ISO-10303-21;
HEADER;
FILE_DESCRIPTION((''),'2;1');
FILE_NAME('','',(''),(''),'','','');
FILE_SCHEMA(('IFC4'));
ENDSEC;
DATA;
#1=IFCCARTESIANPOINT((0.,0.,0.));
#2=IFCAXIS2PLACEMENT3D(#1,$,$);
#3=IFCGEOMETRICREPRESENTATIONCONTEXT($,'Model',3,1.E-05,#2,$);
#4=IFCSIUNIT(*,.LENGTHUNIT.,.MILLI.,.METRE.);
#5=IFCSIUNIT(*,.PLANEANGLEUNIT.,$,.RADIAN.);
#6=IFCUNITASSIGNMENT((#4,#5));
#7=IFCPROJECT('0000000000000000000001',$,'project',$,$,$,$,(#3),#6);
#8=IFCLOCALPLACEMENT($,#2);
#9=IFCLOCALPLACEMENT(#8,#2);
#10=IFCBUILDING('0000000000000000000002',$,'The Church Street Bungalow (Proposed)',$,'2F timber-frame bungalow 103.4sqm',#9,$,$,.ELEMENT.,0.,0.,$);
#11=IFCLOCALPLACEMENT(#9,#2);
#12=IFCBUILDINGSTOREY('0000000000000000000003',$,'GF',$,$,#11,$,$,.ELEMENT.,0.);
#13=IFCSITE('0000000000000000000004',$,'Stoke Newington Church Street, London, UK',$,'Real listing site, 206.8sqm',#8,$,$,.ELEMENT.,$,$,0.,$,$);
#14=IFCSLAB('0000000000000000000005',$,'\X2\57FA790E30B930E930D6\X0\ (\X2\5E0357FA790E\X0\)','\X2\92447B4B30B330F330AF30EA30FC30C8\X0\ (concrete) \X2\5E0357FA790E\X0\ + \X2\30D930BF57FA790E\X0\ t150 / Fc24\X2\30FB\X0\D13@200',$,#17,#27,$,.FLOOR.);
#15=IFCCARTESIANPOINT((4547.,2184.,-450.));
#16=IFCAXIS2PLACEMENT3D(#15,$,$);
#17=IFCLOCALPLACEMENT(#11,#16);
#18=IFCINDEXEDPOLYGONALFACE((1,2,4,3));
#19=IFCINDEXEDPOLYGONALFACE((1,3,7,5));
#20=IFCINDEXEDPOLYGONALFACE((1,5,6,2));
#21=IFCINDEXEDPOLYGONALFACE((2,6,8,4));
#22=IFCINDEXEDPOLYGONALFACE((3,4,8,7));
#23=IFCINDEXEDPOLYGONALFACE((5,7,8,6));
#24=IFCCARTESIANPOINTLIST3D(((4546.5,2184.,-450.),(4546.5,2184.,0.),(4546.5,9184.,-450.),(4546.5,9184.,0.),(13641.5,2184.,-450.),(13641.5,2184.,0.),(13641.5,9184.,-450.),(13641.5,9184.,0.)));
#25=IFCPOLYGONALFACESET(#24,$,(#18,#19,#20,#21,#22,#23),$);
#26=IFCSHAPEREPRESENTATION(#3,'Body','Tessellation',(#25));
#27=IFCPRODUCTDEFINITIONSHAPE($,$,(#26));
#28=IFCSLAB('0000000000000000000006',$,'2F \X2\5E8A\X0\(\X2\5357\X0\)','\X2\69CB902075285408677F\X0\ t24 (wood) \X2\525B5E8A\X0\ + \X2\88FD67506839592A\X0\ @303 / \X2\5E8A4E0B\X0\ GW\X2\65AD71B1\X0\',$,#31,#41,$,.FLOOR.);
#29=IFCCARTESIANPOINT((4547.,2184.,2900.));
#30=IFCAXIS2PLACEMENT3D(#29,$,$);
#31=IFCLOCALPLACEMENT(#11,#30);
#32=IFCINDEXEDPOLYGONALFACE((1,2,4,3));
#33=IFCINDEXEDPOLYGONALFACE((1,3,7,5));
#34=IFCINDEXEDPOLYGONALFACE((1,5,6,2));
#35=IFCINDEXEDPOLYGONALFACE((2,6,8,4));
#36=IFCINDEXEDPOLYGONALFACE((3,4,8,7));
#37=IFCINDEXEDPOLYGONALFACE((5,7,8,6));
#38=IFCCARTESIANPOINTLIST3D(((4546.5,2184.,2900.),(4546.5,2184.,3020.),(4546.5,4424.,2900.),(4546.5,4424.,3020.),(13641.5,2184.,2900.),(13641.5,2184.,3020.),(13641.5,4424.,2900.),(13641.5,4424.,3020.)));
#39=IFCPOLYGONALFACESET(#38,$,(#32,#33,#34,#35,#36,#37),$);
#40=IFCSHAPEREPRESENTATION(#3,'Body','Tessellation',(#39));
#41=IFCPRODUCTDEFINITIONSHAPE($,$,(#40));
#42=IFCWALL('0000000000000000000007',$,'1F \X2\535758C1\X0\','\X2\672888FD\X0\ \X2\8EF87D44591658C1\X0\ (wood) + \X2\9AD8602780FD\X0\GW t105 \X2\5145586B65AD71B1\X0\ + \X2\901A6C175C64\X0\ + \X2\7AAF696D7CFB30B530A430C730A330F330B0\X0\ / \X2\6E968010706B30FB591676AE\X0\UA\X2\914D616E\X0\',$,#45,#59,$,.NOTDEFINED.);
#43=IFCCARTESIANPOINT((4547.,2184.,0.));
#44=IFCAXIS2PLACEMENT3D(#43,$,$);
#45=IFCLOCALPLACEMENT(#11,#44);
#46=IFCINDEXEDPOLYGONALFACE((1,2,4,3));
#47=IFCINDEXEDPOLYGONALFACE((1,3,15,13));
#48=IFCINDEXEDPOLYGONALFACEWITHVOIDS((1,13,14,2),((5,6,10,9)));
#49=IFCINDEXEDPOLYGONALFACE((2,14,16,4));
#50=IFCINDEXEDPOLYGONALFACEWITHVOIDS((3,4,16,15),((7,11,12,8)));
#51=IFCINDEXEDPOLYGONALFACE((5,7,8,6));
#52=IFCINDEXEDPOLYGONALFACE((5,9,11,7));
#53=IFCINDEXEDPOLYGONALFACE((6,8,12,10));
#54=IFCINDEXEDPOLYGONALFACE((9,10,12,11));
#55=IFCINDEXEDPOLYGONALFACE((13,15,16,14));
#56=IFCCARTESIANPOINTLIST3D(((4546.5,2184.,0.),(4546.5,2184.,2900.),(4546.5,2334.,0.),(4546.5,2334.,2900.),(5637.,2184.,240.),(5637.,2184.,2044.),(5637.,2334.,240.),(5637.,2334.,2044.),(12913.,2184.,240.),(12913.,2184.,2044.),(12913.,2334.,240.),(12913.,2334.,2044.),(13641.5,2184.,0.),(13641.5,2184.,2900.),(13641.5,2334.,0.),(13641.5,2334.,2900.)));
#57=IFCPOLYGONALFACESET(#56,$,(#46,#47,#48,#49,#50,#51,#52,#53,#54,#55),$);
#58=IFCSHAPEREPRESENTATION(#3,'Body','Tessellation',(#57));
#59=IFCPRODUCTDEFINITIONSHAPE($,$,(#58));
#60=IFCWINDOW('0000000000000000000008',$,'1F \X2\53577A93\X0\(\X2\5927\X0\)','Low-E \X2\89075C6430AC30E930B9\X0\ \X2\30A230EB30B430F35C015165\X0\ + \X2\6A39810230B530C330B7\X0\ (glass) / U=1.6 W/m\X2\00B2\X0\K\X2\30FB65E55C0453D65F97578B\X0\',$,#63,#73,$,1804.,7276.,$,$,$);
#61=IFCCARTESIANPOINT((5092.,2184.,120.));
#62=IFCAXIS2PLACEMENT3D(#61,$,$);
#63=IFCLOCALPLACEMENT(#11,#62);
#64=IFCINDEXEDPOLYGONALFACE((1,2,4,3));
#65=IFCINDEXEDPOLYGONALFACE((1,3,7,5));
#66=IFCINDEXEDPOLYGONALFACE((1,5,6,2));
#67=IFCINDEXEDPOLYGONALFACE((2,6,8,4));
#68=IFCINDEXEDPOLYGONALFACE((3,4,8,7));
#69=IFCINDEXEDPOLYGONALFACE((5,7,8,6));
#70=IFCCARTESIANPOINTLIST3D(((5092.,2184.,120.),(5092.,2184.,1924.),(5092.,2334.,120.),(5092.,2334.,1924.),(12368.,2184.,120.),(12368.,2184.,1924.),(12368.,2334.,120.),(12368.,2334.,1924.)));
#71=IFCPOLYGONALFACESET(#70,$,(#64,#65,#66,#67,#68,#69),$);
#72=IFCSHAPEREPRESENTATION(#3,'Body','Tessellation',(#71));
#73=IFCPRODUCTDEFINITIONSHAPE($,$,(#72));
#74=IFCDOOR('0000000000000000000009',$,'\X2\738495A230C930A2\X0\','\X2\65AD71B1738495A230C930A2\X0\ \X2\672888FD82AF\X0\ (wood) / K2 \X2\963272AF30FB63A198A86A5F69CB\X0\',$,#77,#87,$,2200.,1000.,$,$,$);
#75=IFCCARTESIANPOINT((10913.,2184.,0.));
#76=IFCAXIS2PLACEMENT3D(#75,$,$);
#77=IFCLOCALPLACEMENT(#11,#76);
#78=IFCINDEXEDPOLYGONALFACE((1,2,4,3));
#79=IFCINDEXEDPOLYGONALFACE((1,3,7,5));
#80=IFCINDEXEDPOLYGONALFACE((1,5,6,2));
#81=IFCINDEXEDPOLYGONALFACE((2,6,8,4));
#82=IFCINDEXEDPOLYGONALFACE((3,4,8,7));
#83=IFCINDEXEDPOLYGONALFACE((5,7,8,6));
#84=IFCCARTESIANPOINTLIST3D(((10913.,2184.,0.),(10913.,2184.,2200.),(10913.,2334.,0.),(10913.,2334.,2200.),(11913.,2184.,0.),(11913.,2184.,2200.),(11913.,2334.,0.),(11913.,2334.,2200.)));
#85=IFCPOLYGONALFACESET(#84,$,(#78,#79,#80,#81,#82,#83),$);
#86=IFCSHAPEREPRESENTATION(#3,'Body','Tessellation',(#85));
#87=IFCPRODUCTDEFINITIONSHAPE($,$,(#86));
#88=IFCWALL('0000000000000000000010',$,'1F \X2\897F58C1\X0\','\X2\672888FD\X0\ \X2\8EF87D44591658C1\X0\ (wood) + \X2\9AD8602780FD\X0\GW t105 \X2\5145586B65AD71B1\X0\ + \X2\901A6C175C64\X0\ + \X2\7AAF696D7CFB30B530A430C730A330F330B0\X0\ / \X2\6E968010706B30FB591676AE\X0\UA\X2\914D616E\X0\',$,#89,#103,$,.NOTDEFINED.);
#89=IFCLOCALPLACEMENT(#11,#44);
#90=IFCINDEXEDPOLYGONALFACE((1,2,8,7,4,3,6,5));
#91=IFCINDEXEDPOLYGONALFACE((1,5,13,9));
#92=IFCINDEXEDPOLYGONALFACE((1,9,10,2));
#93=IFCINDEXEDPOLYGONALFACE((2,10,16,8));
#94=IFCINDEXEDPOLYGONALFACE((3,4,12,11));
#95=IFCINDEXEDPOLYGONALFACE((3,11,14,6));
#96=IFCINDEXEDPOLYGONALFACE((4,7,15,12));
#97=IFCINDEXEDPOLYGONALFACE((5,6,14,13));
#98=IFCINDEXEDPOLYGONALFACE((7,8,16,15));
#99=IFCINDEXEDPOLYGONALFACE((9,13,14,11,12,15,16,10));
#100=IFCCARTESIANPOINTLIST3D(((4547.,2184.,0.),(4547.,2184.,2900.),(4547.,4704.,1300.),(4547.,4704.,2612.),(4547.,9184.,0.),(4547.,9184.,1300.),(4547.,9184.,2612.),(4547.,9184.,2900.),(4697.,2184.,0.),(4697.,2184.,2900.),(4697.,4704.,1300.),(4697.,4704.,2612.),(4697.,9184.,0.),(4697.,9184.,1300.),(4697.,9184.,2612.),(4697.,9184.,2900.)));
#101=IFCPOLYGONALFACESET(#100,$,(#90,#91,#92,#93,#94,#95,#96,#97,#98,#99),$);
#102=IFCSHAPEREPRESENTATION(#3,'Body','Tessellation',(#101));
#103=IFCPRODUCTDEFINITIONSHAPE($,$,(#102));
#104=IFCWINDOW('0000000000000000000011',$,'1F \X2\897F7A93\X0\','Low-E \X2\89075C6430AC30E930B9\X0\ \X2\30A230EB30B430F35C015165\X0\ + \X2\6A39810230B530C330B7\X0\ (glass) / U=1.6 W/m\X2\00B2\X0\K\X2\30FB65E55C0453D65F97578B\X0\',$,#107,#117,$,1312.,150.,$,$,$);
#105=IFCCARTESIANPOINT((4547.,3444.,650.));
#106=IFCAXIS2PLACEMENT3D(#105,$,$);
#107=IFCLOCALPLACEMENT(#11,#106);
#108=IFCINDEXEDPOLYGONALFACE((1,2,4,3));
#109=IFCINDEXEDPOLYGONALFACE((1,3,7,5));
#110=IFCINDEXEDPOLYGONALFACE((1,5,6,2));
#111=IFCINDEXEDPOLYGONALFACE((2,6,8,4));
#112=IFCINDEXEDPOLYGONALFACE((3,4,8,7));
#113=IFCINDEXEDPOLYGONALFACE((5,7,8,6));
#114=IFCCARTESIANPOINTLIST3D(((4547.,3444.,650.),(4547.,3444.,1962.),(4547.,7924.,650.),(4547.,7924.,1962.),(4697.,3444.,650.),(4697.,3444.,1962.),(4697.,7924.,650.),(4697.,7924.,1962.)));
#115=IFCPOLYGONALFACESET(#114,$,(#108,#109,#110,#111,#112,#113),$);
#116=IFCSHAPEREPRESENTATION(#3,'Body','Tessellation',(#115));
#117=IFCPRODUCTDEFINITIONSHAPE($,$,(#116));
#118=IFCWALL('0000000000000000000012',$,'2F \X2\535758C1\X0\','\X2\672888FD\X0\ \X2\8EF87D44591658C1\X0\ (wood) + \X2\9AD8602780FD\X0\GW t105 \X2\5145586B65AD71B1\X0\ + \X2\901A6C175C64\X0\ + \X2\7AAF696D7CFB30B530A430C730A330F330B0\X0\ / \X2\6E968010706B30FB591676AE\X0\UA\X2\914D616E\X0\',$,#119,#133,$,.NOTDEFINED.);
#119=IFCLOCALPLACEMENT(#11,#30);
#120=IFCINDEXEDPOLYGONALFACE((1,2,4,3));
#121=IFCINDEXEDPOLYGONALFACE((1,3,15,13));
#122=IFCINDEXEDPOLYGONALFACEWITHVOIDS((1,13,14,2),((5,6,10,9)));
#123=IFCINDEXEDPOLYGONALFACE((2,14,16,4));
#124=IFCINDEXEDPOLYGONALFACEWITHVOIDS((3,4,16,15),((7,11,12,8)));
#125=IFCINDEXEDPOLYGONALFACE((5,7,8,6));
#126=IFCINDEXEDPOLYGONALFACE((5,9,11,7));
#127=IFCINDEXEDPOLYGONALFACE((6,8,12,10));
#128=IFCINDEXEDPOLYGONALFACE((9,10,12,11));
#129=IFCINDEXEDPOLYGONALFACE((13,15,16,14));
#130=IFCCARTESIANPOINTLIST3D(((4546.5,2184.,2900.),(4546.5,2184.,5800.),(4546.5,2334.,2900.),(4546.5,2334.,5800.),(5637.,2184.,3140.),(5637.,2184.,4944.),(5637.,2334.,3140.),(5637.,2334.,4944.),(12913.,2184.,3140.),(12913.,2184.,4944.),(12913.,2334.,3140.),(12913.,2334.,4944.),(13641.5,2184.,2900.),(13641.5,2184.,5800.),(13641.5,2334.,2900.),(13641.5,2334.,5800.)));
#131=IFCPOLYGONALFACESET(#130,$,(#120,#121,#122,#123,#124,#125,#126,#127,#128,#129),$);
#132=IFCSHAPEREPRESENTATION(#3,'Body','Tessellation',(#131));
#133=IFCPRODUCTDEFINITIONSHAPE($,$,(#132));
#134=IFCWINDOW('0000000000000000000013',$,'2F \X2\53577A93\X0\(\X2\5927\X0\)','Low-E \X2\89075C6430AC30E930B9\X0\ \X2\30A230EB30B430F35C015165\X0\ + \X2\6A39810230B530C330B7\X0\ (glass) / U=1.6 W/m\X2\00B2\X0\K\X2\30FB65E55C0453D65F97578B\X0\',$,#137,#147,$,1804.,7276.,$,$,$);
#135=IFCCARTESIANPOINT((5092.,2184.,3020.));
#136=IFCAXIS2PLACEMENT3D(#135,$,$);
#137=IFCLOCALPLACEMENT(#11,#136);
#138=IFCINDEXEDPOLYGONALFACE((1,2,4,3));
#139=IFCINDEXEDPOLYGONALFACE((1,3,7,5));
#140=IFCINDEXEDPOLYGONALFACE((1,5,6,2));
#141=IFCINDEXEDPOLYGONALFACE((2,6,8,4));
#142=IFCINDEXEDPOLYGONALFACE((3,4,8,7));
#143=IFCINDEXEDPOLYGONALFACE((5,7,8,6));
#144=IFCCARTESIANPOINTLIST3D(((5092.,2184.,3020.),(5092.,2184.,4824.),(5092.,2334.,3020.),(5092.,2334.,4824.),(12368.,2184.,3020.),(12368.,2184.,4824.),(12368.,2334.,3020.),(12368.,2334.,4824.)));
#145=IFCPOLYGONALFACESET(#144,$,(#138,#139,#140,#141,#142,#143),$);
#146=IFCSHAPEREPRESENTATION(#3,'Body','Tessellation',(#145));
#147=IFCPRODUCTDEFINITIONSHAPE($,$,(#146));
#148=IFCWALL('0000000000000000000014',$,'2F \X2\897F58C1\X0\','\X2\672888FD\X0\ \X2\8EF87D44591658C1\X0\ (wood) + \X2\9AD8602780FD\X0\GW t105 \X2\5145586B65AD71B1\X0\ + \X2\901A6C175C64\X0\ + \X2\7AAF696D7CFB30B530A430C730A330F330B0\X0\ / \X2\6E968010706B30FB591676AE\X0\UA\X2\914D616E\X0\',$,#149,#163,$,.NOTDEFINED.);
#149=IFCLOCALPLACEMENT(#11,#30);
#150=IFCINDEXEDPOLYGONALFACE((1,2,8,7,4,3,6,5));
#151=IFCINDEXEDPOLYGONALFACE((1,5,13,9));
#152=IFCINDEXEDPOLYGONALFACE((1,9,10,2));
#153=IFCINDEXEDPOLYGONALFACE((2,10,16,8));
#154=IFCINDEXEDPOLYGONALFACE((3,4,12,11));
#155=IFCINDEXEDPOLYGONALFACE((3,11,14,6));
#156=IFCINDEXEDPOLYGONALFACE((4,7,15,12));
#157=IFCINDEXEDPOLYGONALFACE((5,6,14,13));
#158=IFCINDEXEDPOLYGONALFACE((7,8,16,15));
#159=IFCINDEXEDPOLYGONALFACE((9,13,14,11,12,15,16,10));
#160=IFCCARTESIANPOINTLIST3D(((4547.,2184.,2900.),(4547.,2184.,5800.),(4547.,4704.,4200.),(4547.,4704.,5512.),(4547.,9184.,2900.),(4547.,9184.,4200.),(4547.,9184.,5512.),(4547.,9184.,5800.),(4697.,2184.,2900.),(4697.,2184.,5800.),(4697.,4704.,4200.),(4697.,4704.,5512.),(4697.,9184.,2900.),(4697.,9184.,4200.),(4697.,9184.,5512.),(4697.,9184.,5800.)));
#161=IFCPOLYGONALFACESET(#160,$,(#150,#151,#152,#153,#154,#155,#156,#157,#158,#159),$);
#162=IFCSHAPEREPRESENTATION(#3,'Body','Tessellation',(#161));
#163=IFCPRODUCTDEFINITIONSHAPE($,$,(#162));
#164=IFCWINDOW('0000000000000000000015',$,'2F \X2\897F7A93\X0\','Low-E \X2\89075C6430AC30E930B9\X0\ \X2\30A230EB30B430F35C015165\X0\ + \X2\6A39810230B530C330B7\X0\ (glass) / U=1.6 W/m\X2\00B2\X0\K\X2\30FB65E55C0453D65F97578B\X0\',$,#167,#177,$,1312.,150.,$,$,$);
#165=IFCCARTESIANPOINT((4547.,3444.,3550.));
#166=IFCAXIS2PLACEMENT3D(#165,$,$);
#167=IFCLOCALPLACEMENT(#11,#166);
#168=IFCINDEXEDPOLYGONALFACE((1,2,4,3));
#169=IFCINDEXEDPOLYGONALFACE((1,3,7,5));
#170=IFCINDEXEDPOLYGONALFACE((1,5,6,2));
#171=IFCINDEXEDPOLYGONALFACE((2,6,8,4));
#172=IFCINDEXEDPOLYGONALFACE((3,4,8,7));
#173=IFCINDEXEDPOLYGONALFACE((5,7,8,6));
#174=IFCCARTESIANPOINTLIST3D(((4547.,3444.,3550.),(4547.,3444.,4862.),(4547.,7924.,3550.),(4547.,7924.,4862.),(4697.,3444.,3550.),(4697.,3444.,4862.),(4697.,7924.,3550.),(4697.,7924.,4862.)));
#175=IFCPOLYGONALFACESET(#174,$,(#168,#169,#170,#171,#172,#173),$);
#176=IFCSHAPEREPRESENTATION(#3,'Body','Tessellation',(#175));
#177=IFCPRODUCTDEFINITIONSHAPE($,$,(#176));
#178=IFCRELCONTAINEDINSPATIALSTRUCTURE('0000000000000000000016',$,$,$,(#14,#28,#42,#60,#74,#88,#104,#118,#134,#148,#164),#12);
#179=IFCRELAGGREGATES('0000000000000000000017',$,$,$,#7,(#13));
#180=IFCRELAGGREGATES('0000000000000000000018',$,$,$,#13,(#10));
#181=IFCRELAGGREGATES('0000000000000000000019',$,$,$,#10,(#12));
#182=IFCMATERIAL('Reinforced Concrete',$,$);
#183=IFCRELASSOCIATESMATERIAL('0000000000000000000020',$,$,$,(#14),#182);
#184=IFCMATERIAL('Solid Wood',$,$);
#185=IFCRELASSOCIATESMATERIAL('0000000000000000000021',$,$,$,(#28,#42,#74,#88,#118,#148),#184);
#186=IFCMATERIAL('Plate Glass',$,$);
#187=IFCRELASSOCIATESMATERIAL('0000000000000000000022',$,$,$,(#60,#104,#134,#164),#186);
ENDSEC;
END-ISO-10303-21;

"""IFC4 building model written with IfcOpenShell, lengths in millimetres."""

from ifc_helpers import new_model, si_unit, frame, frame_2d, origin, place, context, project, spatial, rectangle, extrude, material, element, fill, save


model = new_model("IFC4")

# Units and contexts
model_context = context("Model", 3, precision=1e-05, world=origin())
ifc_project = project(units=[si_unit("LENGTHUNIT", "METRE", prefix="MILLI"), si_unit("PLANEANGLEUNIT", "RADIAN")], contexts=[model_context])

# Site, building, storey
site_placement = place(None, origin())
site = spatial("IfcSite", under=ifc_project, at=site_placement, Name="Stoke Newington Church Street, London, UK", ObjectType="Real listing site, 206.8sqm", CompositionType="ELEMENT", RefElevation=0.0)
building_placement = place(site_placement, origin())
building = spatial("IfcBuilding", under=site, at=building_placement, Name="The Church Street Bungalow (Proposed)", ObjectType="2F timber-frame bungalow 103.4sqm", CompositionType="ELEMENT", ElevationOfRefHeight=0.0, ElevationOfTerrain=0.0)
storey_placement = place(building_placement, origin())
storey = spatial("IfcBuildingStorey", under=building, at=storey_placement, Name="GF", CompositionType="ELEMENT", Elevation=0.0)

# Slabs
ifc_material_1 = material(Name="Reinforced Concrete")
slab_1_placement = place(storey_placement, frame((4547.0, 2184.0, -450.0)))
element("IfcSlab", 1, at=slab_1_placement, inside=storey, material=ifc_material_1, Name="基礎スラブ (布基礎)", Description="鉄筋コンクリート (concrete) 布基礎 + ベタ基礎 t150 / Fc24・D13@200", PredefinedType="FLOOR", context=model_context, shape_type="SweptSolid", body=[
    extrude(rectangle(XDim=9095.0, YDim=7000.0, at=frame_2d((4547.0, 3500.0))), frame((4547.0, 2184.0, -450.0)), (0.0, 0.0, 1.0), 450.0),
])
ifc_material_2 = material(Name="Solid Wood")
slab_2_placement = place(storey_placement, frame((4547.0, 2184.0, 2900.0)))
element("IfcSlab", 2, at=slab_2_placement, inside=storey, material=ifc_material_2, Name="2F 床(南)", Description="構造用合板 t24 (wood) 剛床 + 製材根太 @303 / 床下 GW断熱", PredefinedType="FLOOR", context=model_context, shape_type="SweptSolid", body=[
    extrude(rectangle(XDim=9095.0, YDim=2240.0, at=frame_2d((4547.0, 1120.0))), frame((4547.0, 2184.0, 2900.0)), (0.0, 0.0, 1.0), 120.0),
])

# Wall, openings, window, door
wall_1_placement = place(storey_placement, frame((4547.0, 2184.0, 0.0)))
wall_1 = element("IfcWall", 3, at=wall_1_placement, inside=storey, material=ifc_material_2, Name="1F 南壁", Description="木製 軸組外壁 (wood) + 高性能GW t105 充填断熱 + 通気層 + 窯業系サイディング / 準耐火・外皮UA配慮", PredefinedType="NOTDEFINED", context=model_context, shape_type="SweptSolid", body=[
    extrude(rectangle(XDim=9095.0, YDim=150.0, at=frame_2d((4547.0, 75.0))), frame((4547.0, 2184.0, 0.0)), (0.0, 0.0, 1.0), 2900.0),
])
opening_1_placement = place(storey_placement, frame((5092.0, 2184.0, 120.0)))
opening_1 = element("IfcOpeningElement", 4, at=opening_1_placement, cuts=wall_1, PredefinedType="NOTDEFINED", context=model_context, shape_type="SweptSolid", body=[
    extrude(rectangle(XDim=7276.0, YDim=150.0, at=frame_2d((3638.0, 75.0))), frame((5092.0, 2184.0, 120.0)), (0.0, 0.0, 1.0), 1804.0),
])
opening_2_placement = place(storey_placement, frame((10913.0, 2184.0, 0.0)))
opening_2 = element("IfcOpeningElement", 5, at=opening_2_placement, cuts=wall_1, PredefinedType="NOTDEFINED", context=model_context, shape_type="SweptSolid", body=[
    extrude(rectangle(XDim=1000.0, YDim=150.0, at=frame_2d((500.0, 75.0))), frame((10913.0, 2184.0, 0.0)), (0.0, 0.0, 1.0), 2200.0),
])
ifc_material_3 = material(Name="Plate Glass")
window_1_placement = place(storey_placement, frame((5092.0, 2184.0, 120.0)))
window_1 = element("IfcWindow", 6, at=window_1_placement, inside=storey, material=ifc_material_3, Name="1F 南窓(大)", Description="Low-E 複層ガラス アルゴン封入 + 樹脂サッシ (glass) / U=1.6 W/m²K・日射取得型", OverallHeight=1804.0, OverallWidth=7276.0, context=model_context, shape_type="SweptSolid", body=[
    extrude(rectangle(XDim=7276.0, YDim=150.0, at=frame_2d((3638.0, 75.0))), frame((5092.0, 2184.0, 120.0)), (0.0, 0.0, 1.0), 1804.0),
])
fill(opening_1, window_1)
door_placement = place(storey_placement, frame((10913.0, 2184.0, 0.0)))
door = element("IfcDoor", 7, at=door_placement, inside=storey, material=ifc_material_2, Name="玄関ドア", Description="断熱玄関ドア 木製芯 (wood) / K2 防犯・採風機構", OverallHeight=2200.0, OverallWidth=1000.0, context=model_context, shape_type="SweptSolid", body=[
    extrude(rectangle(XDim=1000.0, YDim=150.0, at=frame_2d((500.0, 75.0))), frame((10913.0, 2184.0, 0.0)), (0.0, 0.0, 1.0), 2200.0),
])
fill(opening_2, door)

# Walls, openings, windows
wall_2_placement = place(storey_placement, frame((4547.0, 2184.0, 0.0)))
wall_2 = element("IfcWall", 8, at=wall_2_placement, inside=storey, material=ifc_material_2, Name="1F 西壁", Description="木製 軸組外壁 (wood) + 高性能GW t105 充填断熱 + 通気層 + 窯業系サイディング / 準耐火・外皮UA配慮", PredefinedType="NOTDEFINED", context=model_context, shape_type="SweptSolid", body=[
    extrude(rectangle(XDim=150.0, YDim=7000.0, at=frame_2d((75.0, 3500.0))), frame((4547.0, 2184.0, 0.0)), (0.0, 0.0, 1.0), 2900.0),
])
opening_3_placement = place(storey_placement, frame((4547.0, 3444.0, 650.0)))
opening_3 = element("IfcOpeningElement", 9, at=opening_3_placement, cuts=wall_2, PredefinedType="NOTDEFINED", context=model_context, shape_type="SweptSolid", body=[
    extrude(rectangle(XDim=150.0, YDim=4480.0, at=frame_2d((75.0, 2240.0))), frame((4547.0, 3444.0, 650.0)), (0.0, 0.0, 1.0), 1312.0),
])
window_2_placement = place(storey_placement, frame((4547.0, 3444.0, 650.0)))
window_2 = element("IfcWindow", 10, at=window_2_placement, inside=storey, material=ifc_material_3, Name="1F 西窓", Description="Low-E 複層ガラス アルゴン封入 + 樹脂サッシ (glass) / U=1.6 W/m²K・日射取得型", OverallHeight=1312.0, OverallWidth=150.0, context=model_context, shape_type="SweptSolid", body=[
    extrude(rectangle(XDim=150.0, YDim=4480.0, at=frame_2d((75.0, 2240.0))), frame((4547.0, 3444.0, 650.0)), (0.0, 0.0, 1.0), 1312.0),
])
fill(opening_3, window_2)
wall_3_placement = place(storey_placement, frame((4547.0, 2184.0, 2900.0)))
wall_3 = element("IfcWall", 11, at=wall_3_placement, inside=storey, material=ifc_material_2, Name="2F 南壁", Description="木製 軸組外壁 (wood) + 高性能GW t105 充填断熱 + 通気層 + 窯業系サイディング / 準耐火・外皮UA配慮", PredefinedType="NOTDEFINED", context=model_context, shape_type="SweptSolid", body=[
    extrude(rectangle(XDim=9095.0, YDim=150.0, at=frame_2d((4547.0, 75.0))), frame((4547.0, 2184.0, 2900.0)), (0.0, 0.0, 1.0), 2900.0),
])
opening_4_placement = place(storey_placement, frame((5092.0, 2184.0, 3020.0)))
opening_4 = element("IfcOpeningElement", 12, at=opening_4_placement, cuts=wall_3, PredefinedType="NOTDEFINED", context=model_context, shape_type="SweptSolid", body=[
    extrude(rectangle(XDim=7276.0, YDim=150.0, at=frame_2d((3638.0, 75.0))), frame((5092.0, 2184.0, 3020.0)), (0.0, 0.0, 1.0), 1804.0),
])
window_3_placement = place(storey_placement, frame((5092.0, 2184.0, 3020.0)))
window_3 = element("IfcWindow", 13, at=window_3_placement, inside=storey, material=ifc_material_3, Name="2F 南窓(大)", Description="Low-E 複層ガラス アルゴン封入 + 樹脂サッシ (glass) / U=1.6 W/m²K・日射取得型", OverallHeight=1804.0, OverallWidth=7276.0, context=model_context, shape_type="SweptSolid", body=[
    extrude(rectangle(XDim=7276.0, YDim=150.0, at=frame_2d((3638.0, 75.0))), frame((5092.0, 2184.0, 3020.0)), (0.0, 0.0, 1.0), 1804.0),
])
fill(opening_4, window_3)
wall_4_placement = place(storey_placement, frame((4547.0, 2184.0, 2900.0)))
wall_4 = element("IfcWall", 14, at=wall_4_placement, inside=storey, material=ifc_material_2, Name="2F 西壁", Description="木製 軸組外壁 (wood) + 高性能GW t105 充填断熱 + 通気層 + 窯業系サイディング / 準耐火・外皮UA配慮", PredefinedType="NOTDEFINED", context=model_context, shape_type="SweptSolid", body=[
    extrude(rectangle(XDim=150.0, YDim=7000.0, at=frame_2d((75.0, 3500.0))), frame((4547.0, 2184.0, 2900.0)), (0.0, 0.0, 1.0), 2900.0),
])
opening_5_placement = place(storey_placement, frame((4547.0, 3444.0, 3550.0)))
opening_5 = element("IfcOpeningElement", 15, at=opening_5_placement, cuts=wall_4, PredefinedType="NOTDEFINED", context=model_context, shape_type="SweptSolid", body=[
    extrude(rectangle(XDim=150.0, YDim=4480.0, at=frame_2d((75.0, 2240.0))), frame((4547.0, 3444.0, 3550.0)), (0.0, 0.0, 1.0), 1312.0),
])
window_4_placement = place(storey_placement, frame((4547.0, 3444.0, 3550.0)))
window_4 = element("IfcWindow", 16, at=window_4_placement, inside=storey, material=ifc_material_3, Name="2F 西窓", Description="Low-E 複層ガラス アルゴン封入 + 樹脂サッシ (glass) / U=1.6 W/m²K・日射取得型", OverallHeight=1312.0, OverallWidth=150.0, context=model_context, shape_type="SweptSolid", body=[
    extrude(rectangle(XDim=150.0, YDim=4480.0, at=frame_2d((75.0, 2240.0))), frame((4547.0, 3444.0, 3550.0)), (0.0, 0.0, 1.0), 1312.0),
])
fill(opening_5, window_4)

save(model, "model.ifc")
